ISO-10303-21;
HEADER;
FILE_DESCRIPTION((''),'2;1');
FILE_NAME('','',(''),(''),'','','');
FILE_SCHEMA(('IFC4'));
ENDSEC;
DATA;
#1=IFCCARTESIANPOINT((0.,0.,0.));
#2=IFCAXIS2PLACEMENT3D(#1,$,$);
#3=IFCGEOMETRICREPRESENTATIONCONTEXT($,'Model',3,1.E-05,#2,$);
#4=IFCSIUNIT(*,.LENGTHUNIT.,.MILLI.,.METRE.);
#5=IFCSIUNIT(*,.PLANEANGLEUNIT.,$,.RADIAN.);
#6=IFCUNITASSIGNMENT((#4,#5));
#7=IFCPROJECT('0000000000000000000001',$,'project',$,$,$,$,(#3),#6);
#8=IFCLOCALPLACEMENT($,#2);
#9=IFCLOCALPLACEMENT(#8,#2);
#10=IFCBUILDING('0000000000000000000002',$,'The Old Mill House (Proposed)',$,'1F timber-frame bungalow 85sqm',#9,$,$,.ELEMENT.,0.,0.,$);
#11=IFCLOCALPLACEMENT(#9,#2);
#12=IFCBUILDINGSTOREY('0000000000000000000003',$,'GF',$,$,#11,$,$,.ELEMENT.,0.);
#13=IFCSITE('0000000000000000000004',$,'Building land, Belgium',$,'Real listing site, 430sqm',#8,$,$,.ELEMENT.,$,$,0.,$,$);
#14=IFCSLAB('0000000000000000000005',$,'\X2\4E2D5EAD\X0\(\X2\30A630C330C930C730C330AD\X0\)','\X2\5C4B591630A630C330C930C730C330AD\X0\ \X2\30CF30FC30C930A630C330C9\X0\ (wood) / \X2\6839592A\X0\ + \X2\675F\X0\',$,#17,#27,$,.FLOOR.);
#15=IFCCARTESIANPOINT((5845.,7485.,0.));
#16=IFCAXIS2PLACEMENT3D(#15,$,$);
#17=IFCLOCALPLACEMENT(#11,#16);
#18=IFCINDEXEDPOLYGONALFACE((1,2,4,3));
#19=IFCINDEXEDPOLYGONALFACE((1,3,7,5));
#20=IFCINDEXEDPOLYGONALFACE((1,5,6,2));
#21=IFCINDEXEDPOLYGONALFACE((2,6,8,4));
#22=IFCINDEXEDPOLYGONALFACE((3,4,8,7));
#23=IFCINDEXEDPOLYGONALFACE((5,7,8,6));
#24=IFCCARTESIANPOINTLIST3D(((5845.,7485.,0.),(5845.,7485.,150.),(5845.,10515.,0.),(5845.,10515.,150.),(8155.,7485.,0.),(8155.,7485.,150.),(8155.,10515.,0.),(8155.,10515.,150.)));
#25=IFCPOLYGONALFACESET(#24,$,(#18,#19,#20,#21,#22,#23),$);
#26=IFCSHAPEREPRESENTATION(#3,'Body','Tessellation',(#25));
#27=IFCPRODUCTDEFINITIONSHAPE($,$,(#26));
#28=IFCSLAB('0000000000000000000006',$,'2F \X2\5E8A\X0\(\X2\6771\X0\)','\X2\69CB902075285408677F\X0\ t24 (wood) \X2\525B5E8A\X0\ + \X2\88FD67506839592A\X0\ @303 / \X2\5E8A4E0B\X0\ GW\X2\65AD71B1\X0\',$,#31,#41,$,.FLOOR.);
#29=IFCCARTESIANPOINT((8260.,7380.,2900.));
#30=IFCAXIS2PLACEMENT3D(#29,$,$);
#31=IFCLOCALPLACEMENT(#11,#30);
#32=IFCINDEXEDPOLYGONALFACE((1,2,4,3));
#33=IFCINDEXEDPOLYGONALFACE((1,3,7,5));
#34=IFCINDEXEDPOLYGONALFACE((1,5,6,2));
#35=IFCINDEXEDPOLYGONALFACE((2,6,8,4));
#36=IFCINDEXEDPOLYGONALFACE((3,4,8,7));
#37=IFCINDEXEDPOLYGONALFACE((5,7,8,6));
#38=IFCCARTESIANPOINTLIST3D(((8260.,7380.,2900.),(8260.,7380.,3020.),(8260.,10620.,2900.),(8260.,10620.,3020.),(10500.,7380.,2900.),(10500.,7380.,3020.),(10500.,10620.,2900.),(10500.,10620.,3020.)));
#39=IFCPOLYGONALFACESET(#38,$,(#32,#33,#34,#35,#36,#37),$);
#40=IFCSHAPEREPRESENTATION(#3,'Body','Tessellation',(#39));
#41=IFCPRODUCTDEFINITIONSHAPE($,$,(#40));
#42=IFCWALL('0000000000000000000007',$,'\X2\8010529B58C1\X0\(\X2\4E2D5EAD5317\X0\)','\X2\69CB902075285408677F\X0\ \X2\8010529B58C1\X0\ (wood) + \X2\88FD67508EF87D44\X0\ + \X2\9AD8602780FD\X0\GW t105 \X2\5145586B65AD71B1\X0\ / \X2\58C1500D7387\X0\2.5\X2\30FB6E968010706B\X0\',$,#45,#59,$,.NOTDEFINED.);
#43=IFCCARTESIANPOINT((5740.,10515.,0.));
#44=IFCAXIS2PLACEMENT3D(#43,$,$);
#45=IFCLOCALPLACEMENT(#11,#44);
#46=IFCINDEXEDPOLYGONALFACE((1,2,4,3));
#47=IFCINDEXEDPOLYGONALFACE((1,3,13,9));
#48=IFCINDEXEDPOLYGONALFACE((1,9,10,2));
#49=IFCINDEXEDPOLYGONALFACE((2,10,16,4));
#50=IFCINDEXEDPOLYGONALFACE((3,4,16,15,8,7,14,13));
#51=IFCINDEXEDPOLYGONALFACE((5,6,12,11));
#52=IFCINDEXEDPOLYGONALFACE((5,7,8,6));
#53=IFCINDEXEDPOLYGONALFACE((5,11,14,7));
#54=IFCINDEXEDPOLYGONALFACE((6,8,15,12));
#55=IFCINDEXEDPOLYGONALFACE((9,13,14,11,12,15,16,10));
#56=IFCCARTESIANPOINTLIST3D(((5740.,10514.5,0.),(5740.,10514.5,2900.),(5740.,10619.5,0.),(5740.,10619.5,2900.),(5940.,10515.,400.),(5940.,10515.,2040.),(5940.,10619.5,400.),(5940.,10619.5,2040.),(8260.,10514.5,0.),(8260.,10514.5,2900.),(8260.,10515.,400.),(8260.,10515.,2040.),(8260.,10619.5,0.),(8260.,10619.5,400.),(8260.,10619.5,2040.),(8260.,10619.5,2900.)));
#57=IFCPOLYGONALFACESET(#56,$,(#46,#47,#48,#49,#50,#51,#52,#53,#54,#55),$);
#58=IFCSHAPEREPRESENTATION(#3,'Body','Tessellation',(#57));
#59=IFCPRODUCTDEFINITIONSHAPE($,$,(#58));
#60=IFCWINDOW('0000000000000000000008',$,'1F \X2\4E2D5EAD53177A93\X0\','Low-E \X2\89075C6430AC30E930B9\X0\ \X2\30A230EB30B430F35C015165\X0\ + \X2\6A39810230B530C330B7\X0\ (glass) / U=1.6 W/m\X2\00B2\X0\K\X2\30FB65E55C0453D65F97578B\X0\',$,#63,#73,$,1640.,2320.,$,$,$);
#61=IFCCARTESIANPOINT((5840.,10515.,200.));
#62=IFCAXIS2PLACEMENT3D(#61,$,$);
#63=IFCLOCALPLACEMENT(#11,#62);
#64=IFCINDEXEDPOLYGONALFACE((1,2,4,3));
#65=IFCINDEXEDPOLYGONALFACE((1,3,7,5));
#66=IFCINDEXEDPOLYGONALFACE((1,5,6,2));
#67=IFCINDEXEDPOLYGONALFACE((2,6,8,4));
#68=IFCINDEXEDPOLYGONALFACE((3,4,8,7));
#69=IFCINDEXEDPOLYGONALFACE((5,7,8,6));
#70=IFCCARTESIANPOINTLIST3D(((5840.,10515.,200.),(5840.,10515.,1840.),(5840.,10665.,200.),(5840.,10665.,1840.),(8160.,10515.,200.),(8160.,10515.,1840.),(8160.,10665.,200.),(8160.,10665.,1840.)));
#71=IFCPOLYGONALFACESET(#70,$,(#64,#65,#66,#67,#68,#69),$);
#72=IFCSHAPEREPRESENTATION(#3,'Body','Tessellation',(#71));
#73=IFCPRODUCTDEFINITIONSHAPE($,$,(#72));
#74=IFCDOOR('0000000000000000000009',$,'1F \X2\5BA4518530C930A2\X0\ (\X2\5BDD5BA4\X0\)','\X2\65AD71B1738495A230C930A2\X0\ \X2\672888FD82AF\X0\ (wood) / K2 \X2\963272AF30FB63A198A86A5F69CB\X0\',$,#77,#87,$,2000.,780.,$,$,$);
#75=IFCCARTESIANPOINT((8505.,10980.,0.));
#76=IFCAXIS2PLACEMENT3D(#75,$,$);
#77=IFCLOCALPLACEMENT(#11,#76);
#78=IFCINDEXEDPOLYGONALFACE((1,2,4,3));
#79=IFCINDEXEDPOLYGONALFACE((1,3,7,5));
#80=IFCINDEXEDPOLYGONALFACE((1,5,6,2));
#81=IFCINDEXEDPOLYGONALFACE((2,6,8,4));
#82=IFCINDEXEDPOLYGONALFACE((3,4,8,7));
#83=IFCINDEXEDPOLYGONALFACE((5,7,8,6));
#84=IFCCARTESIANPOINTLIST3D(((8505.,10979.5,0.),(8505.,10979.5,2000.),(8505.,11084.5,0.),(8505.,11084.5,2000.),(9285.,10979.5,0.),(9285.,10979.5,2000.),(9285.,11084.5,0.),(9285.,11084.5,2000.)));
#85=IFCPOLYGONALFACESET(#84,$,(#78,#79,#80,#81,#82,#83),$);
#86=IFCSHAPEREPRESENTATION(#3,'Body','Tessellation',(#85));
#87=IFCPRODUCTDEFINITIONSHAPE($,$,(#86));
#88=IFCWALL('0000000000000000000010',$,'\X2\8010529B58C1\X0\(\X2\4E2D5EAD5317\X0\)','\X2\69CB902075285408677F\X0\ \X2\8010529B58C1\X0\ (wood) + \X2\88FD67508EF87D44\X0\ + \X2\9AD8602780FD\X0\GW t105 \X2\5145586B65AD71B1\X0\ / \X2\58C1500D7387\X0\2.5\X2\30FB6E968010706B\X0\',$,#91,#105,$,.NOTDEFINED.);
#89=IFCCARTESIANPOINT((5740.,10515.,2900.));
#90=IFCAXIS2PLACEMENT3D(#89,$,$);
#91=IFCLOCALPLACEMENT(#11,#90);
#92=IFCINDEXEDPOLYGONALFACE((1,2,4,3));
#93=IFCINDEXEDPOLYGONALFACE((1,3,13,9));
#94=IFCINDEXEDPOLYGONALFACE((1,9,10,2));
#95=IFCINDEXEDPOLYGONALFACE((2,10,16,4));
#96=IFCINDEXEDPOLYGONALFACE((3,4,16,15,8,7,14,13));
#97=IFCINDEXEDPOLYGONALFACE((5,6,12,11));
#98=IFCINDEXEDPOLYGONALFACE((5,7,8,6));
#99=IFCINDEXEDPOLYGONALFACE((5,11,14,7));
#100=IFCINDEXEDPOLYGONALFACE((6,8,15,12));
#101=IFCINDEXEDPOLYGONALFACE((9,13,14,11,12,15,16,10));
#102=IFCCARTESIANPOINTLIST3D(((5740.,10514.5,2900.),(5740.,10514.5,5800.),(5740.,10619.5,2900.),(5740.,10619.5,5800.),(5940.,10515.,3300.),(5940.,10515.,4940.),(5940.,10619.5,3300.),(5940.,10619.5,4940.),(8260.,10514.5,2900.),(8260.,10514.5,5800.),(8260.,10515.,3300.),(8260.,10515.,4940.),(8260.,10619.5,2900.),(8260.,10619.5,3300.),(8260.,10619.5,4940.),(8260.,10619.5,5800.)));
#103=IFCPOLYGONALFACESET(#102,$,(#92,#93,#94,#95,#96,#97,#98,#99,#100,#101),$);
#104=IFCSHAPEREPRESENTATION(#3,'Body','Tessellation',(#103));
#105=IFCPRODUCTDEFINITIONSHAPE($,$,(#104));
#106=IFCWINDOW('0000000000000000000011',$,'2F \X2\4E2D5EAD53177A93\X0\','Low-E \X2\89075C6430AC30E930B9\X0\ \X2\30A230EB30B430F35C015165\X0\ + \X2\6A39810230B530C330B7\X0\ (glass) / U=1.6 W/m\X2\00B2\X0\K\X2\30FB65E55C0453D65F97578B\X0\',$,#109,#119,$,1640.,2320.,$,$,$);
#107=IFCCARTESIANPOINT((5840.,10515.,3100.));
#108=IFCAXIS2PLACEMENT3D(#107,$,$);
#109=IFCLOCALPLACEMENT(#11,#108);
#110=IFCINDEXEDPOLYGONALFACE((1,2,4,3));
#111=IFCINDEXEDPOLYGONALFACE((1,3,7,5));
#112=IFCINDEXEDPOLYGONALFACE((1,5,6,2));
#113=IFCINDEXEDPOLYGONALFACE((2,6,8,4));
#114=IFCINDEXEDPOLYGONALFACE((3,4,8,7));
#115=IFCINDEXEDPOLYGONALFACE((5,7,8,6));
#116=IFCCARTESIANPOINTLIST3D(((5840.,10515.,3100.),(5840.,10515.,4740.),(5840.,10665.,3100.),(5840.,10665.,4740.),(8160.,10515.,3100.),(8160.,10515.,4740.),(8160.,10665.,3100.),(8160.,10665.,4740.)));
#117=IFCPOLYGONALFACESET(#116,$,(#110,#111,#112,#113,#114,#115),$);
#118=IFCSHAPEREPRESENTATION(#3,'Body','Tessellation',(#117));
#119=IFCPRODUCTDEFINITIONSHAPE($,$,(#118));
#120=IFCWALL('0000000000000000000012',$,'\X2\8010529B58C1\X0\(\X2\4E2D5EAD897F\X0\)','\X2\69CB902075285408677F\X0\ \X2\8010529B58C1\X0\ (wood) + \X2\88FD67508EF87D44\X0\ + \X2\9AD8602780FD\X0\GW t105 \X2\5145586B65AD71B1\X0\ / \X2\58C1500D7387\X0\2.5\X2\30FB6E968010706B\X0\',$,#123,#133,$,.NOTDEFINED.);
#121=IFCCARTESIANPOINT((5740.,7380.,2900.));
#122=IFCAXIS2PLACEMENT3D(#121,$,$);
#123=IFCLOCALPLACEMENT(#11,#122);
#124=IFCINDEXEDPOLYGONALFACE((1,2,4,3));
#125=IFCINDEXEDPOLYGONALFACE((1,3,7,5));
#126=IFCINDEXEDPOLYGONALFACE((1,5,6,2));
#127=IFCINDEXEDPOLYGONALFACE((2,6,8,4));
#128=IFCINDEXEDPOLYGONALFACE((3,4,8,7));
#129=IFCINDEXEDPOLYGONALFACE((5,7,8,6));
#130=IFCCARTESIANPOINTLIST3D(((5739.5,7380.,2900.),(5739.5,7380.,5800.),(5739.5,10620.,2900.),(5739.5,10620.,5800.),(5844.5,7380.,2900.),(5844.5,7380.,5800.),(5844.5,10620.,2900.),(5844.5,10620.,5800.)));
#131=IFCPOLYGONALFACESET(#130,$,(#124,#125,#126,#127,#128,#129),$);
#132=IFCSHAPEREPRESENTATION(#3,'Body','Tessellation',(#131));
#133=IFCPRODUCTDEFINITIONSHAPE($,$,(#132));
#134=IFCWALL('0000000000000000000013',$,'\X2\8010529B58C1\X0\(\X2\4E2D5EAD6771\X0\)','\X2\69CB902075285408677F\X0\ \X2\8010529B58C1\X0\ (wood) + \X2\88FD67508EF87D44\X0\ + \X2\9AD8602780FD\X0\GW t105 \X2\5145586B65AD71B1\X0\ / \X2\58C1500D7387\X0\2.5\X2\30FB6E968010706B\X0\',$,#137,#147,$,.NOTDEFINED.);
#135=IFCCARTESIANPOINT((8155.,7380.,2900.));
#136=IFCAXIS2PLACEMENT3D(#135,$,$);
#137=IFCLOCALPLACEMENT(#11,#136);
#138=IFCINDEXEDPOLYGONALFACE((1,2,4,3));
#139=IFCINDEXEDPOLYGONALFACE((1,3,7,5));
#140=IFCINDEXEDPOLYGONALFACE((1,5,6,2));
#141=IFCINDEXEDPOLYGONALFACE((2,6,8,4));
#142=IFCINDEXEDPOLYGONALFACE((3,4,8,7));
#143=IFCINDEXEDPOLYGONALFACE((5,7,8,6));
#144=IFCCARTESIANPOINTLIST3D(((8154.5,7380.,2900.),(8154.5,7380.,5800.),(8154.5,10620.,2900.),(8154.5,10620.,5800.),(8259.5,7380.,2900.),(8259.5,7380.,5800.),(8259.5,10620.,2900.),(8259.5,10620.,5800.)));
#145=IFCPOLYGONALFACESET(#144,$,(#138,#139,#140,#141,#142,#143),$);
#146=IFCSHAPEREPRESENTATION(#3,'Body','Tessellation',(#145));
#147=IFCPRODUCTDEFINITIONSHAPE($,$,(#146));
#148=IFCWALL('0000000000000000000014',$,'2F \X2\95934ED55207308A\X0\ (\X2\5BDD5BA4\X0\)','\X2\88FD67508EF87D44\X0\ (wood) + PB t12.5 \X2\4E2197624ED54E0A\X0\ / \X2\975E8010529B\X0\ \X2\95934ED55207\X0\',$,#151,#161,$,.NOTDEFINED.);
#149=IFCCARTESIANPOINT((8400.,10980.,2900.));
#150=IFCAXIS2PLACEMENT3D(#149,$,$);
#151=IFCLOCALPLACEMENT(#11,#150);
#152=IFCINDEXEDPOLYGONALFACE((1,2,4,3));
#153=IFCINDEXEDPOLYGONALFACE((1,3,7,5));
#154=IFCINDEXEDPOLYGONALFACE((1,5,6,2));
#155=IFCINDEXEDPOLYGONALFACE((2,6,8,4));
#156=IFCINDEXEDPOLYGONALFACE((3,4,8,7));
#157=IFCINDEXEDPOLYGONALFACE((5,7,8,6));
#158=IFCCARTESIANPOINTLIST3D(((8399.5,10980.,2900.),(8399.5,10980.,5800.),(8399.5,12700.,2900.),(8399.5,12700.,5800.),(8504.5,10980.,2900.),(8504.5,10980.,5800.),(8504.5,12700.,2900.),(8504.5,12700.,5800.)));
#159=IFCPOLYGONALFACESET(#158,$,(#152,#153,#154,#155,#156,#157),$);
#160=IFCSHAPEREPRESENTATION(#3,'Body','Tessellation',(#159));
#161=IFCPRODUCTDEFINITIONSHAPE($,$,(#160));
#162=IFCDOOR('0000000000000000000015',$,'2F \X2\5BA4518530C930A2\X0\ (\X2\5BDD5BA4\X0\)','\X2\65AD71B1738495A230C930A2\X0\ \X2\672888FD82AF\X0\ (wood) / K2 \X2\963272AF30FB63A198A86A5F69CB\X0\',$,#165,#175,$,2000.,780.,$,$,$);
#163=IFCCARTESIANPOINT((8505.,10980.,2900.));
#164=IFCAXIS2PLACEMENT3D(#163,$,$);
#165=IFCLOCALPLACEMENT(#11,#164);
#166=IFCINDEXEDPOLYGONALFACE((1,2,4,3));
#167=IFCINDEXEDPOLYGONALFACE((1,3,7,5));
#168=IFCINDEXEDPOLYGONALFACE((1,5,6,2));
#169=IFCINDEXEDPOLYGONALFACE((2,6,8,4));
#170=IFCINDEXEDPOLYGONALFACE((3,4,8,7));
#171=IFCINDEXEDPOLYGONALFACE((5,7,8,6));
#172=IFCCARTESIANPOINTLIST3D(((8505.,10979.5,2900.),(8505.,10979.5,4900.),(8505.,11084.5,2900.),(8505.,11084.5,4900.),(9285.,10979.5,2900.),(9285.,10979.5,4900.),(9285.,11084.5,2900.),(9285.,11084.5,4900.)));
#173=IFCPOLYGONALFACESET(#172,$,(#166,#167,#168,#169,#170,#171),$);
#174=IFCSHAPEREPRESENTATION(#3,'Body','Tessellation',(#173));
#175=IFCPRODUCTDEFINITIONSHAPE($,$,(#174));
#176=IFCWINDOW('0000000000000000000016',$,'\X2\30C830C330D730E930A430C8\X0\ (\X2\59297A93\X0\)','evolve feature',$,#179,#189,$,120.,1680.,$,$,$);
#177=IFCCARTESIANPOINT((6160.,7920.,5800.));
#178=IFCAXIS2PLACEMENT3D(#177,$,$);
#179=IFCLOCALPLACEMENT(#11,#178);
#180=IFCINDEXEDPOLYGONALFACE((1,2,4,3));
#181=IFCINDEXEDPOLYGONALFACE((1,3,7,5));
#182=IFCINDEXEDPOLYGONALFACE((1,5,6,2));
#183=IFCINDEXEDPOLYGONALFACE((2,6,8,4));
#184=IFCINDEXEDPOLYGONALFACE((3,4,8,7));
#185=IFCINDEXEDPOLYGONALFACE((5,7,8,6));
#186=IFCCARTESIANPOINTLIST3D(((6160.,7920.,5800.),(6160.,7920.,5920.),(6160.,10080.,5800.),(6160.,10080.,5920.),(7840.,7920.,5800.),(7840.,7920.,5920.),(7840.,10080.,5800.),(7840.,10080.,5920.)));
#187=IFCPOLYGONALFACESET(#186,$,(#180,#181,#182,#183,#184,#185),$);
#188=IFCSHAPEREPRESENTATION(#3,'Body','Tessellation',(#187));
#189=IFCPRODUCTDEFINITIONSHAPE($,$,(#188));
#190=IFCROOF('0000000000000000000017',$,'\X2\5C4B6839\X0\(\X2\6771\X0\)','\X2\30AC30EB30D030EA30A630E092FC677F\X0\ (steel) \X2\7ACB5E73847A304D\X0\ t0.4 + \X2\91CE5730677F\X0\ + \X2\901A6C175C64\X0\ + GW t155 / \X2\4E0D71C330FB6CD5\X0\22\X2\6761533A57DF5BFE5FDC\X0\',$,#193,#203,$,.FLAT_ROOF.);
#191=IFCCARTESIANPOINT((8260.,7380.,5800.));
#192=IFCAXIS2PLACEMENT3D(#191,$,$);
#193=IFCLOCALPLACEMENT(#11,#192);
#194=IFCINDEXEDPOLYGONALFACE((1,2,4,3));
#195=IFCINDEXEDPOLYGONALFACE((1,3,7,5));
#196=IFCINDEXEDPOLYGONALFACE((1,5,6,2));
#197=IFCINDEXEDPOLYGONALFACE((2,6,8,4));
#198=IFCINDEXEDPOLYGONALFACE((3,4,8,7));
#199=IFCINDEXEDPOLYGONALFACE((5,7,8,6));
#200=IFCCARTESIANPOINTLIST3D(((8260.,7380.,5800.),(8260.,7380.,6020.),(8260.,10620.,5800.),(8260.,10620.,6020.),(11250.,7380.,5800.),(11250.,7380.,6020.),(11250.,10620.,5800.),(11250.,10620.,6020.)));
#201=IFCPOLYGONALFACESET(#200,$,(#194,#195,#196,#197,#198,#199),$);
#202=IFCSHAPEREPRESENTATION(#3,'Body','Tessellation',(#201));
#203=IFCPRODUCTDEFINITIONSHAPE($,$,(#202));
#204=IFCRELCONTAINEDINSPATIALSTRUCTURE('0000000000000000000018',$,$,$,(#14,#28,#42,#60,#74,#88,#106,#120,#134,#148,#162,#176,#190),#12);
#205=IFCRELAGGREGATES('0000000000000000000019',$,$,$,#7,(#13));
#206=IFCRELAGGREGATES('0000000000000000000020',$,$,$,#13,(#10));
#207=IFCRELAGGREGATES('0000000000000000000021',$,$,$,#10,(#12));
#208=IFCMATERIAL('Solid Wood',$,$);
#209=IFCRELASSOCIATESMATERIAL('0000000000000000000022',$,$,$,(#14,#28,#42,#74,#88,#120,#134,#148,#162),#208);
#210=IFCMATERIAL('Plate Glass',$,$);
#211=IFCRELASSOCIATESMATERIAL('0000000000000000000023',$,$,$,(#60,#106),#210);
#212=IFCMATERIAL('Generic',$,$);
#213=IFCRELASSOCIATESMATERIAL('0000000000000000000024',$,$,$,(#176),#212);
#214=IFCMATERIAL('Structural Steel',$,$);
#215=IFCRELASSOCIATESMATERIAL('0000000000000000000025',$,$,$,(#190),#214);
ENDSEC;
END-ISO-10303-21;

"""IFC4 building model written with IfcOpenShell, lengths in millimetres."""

from ifc_helpers import new_model, si_unit, frame, frame_2d, origin, place, context, project, spatial, rectangle, extrude, material, element, fill, save


model = new_model("IFC4")

# Units and contexts
model_context = context("Model", 3, precision=1e-05, world=origin())
ifc_project = project(units=[si_unit("LENGTHUNIT", "METRE", prefix="MILLI"), si_unit("PLANEANGLEUNIT", "RADIAN")], contexts=[model_context])

# Site, building, storey
site_placement = place(None, origin())
site = spatial("IfcSite", under=ifc_project, at=site_placement, Name="Building land, Belgium", ObjectType="Real listing site, 430sqm", CompositionType="ELEMENT", RefElevation=0.0)
building_placement = place(site_placement, origin())
building = spatial("IfcBuilding", under=site, at=building_placement, Name="The Old Mill House (Proposed)", ObjectType="1F timber-frame bungalow 85sqm", CompositionType="ELEMENT", ElevationOfRefHeight=0.0, ElevationOfTerrain=0.0)
storey_placement = place(building_placement, origin())
storey = spatial("IfcBuildingStorey", under=building, at=storey_placement, Name="GF", CompositionType="ELEMENT", Elevation=0.0)

# Slabs
ifc_material_1 = material(Name="Solid Wood")
slab_1_placement = place(storey_placement, frame((5845.0, 7485.0, 0.0)))
element("IfcSlab", 1, at=slab_1_placement, inside=storey, material=ifc_material_1, Name="中庭(ウッドデッキ)", Description="屋外ウッドデッキ ハードウッド (wood) / 根太 + 束", PredefinedType="FLOOR", context=model_context, shape_type="SweptSolid", body=[
    extrude(rectangle(XDim=2310.0, YDim=3030.0, at=frame_2d((1155.0, 1515.0))), frame((5845.0, 7485.0, 0.0)), (0.0, 0.0, 1.0), 150.0),
])
slab_2_placement = place(storey_placement, frame((8260.0, 7380.0, 2900.0)))
element("IfcSlab", 2, at=slab_2_placement, inside=storey, material=ifc_material_1, Name="2F 床(東)", Description="構造用合板 t24 (wood) 剛床 + 製材根太 @303 / 床下 GW断熱", PredefinedType="FLOOR", context=model_context, shape_type="SweptSolid", body=[
    extrude(rectangle(XDim=2240.0, YDim=3240.0, at=frame_2d((1120.0, 1620.0))), frame((8260.0, 7380.0, 2900.0)), (0.0, 0.0, 1.0), 120.0),
])

# Wall, opening, window
wall_1_placement = place(storey_placement, frame((5740.0, 10515.0, 0.0)))
wall_1 = element("IfcWall", 3, at=wall_1_placement, inside=storey, material=ifc_material_1, Name="耐力壁(中庭北)", Description="構造用合板 耐力壁 (wood) + 製材軸組 + 高性能GW t105 充填断熱 / 壁倍率2.5・準耐火", PredefinedType="NOTDEFINED", context=model_context, shape_type="SweptSolid", body=[
    extrude(rectangle(XDim=2520.0, YDim=105.0, at=frame_2d((1260.0, 52.0))), frame((5740.0, 10515.0, 0.0)), (0.0, 0.0, 1.0), 2900.0),
])
opening_1_placement = place(storey_placement, frame((5840.0, 10515.0, 200.0)))
opening_1 = element("IfcOpeningElement", 4, at=opening_1_placement, cuts=wall_1, PredefinedType="NOTDEFINED", context=model_context, shape_type="SweptSolid", body=[
    extrude(rectangle(XDim=2320.0, YDim=150.0, at=frame_2d((1160.0, 75.0))), frame((5840.0, 10515.0, 200.0)), (0.0, 0.0, 1.0), 1640.0),
])
ifc_material_2 = material(Name="Plate Glass")
window_1_placement = place(storey_placement, frame((5840.0, 10515.0, 200.0)))
window_1 = element("IfcWindow", 5, at=window_1_placement, inside=storey, material=ifc_material_2, Name="1F 中庭北窓", Description="Low-E 複層ガラス アルゴン封入 + 樹脂サッシ (glass) / U=1.6 W/m²K・日射取得型", OverallHeight=1640.0, OverallWidth=2320.0, context=model_context, shape_type="SweptSolid", body=[
    extrude(rectangle(XDim=2320.0, YDim=150.0, at=frame_2d((1160.0, 75.0))), frame((5840.0, 10515.0, 200.0)), (0.0, 0.0, 1.0), 1640.0),
])
fill(opening_1, window_1)

# Door
door_1_placement = place(storey_placement, frame((8505.0, 10980.0, 0.0)))
element("IfcDoor", 6, at=door_1_placement, inside=storey, material=ifc_material_1, Name="1F 室内ドア (寝室)", Description="断熱玄関ドア 木製芯 (wood) / K2 防犯・採風機構", OverallHeight=2000.0, OverallWidth=780.0, context=model_context, shape_type="SweptSolid", body=[
    extrude(rectangle(XDim=780.0, YDim=105.0, at=frame_2d((390.0, 52.0))), frame((8505.0, 10980.0, 0.0)), (0.0, 0.0, 1.0), 2000.0),
])

# Wall, opening, window
wall_2_placement = place(storey_placement, frame((5740.0, 10515.0, 2900.0)))
wall_2 = element("IfcWall", 7, at=wall_2_placement, inside=storey, material=ifc_material_1, Name="耐力壁(中庭北)", Description="構造用合板 耐力壁 (wood) + 製材軸組 + 高性能GW t105 充填断熱 / 壁倍率2.5・準耐火", PredefinedType="NOTDEFINED", context=model_context, shape_type="SweptSolid", body=[
    extrude(rectangle(XDim=2520.0, YDim=105.0, at=frame_2d((1260.0, 52.0))), frame((5740.0, 10515.0, 2900.0)), (0.0, 0.0, 1.0), 2900.0),
])
opening_2_placement = place(storey_placement, frame((5840.0, 10515.0, 3100.0)))
opening_2 = element("IfcOpeningElement", 8, at=opening_2_placement, cuts=wall_2, PredefinedType="NOTDEFINED", context=model_context, shape_type="SweptSolid", body=[
    extrude(rectangle(XDim=2320.0, YDim=150.0, at=frame_2d((1160.0, 75.0))), frame((5840.0, 10515.0, 3100.0)), (0.0, 0.0, 1.0), 1640.0),
])
window_2_placement = place(storey_placement, frame((5840.0, 10515.0, 3100.0)))
window_2 = element("IfcWindow", 9, at=window_2_placement, inside=storey, material=ifc_material_2, Name="2F 中庭北窓", Description="Low-E 複層ガラス アルゴン封入 + 樹脂サッシ (glass) / U=1.6 W/m²K・日射取得型", OverallHeight=1640.0, OverallWidth=2320.0, context=model_context, shape_type="SweptSolid", body=[
    extrude(rectangle(XDim=2320.0, YDim=150.0, at=frame_2d((1160.0, 75.0))), frame((5840.0, 10515.0, 3100.0)), (0.0, 0.0, 1.0), 1640.0),
])
fill(opening_2, window_2)

# Walls
wall_3_placement = place(storey_placement, frame((5740.0, 7380.0, 2900.0)))
element("IfcWall", 10, at=wall_3_placement, inside=storey, material=ifc_material_1, Name="耐力壁(中庭西)", Description="構造用合板 耐力壁 (wood) + 製材軸組 + 高性能GW t105 充填断熱 / 壁倍率2.5・準耐火", PredefinedType="NOTDEFINED", context=model_context, shape_type="SweptSolid", body=[
    extrude(rectangle(XDim=105.0, YDim=3240.0, at=frame_2d((52.0, 1620.0))), frame((5740.0, 7380.0, 2900.0)), (0.0, 0.0, 1.0), 2900.0),
])
wall_4_placement = place(storey_placement, frame((8155.0, 7380.0, 2900.0)))
element("IfcWall", 11, at=wall_4_placement, inside=storey, material=ifc_material_1, Name="耐力壁(中庭東)", Description="構造用合板 耐力壁 (wood) + 製材軸組 + 高性能GW t105 充填断熱 / 壁倍率2.5・準耐火", PredefinedType="NOTDEFINED", context=model_context, shape_type="SweptSolid", body=[
    extrude(rectangle(XDim=105.0, YDim=3240.0, at=frame_2d((52.0, 1620.0))), frame((8155.0, 7380.0, 2900.0)), (0.0, 0.0, 1.0), 2900.0),
])
wall_5_placement = place(storey_placement, frame((8400.0, 10980.0, 2900.0)))
element("IfcWall", 12, at=wall_5_placement, inside=storey, material=ifc_material_1, Name="2F 間仕切り (寝室)", Description="製材軸組 (wood) + PB t12.5 両面仕上 / 非耐力 間仕切", PredefinedType="NOTDEFINED", context=model_context, shape_type="SweptSolid", body=[
    extrude(rectangle(XDim=105.0, YDim=1720.0, at=frame_2d((52.0, 860.0))), frame((8400.0, 10980.0, 2900.0)), (0.0, 0.0, 1.0), 2900.0),
])

# Door
door_2_placement = place(storey_placement, frame((8505.0, 10980.0, 2900.0)))
element("IfcDoor", 13, at=door_2_placement, inside=storey, material=ifc_material_1, Name="2F 室内ドア (寝室)", Description="断熱玄関ドア 木製芯 (wood) / K2 防犯・採風機構", OverallHeight=2000.0, OverallWidth=780.0, context=model_context, shape_type="SweptSolid", body=[
    extrude(rectangle(XDim=780.0, YDim=105.0, at=frame_2d((390.0, 52.0))), frame((8505.0, 10980.0, 2900.0)), (0.0, 0.0, 1.0), 2000.0),
])

# Window
ifc_material_3 = material(Name="Generic")
window_3_placement = place(storey_placement, frame((6160.0, 7920.0, 5800.0)))
element("IfcWindow", 14, at=window_3_placement, inside=storey, material=ifc_material_3, Name="トップライト (天窓)", Description="evolve feature", OverallHeight=120.0, OverallWidth=1680.0, context=model_context, shape_type="SweptSolid", body=[
    extrude(rectangle(XDim=1680.0, YDim=2160.0, at=frame_2d((840.0, 1080.0))), frame((6160.0, 7920.0, 5800.0)), (0.0, 0.0, 1.0), 120.0),
])

# Roof
ifc_material_4 = material(Name="Structural Steel")
roof_placement = place(storey_placement, frame((8260.0, 7380.0, 5800.0)))
element("IfcRoof", 15, at=roof_placement, inside=storey, material=ifc_material_4, Name="屋根(東)", Description="ガルバリウム鋼板 (steel) 立平葺き t0.4 + 野地板 + 通気層 + GW t155 / 不燃・法22条区域対応", PredefinedType="FLAT_ROOF", context=model_context, shape_type="SweptSolid", body=[
    extrude(rectangle(XDim=2990.0, YDim=3240.0, at=frame_2d((1495.0, 1620.0))), frame((8260.0, 7380.0, 5800.0)), (0.0, 0.0, 1.0), 220.0),
])

save(model, "model.ifc")
